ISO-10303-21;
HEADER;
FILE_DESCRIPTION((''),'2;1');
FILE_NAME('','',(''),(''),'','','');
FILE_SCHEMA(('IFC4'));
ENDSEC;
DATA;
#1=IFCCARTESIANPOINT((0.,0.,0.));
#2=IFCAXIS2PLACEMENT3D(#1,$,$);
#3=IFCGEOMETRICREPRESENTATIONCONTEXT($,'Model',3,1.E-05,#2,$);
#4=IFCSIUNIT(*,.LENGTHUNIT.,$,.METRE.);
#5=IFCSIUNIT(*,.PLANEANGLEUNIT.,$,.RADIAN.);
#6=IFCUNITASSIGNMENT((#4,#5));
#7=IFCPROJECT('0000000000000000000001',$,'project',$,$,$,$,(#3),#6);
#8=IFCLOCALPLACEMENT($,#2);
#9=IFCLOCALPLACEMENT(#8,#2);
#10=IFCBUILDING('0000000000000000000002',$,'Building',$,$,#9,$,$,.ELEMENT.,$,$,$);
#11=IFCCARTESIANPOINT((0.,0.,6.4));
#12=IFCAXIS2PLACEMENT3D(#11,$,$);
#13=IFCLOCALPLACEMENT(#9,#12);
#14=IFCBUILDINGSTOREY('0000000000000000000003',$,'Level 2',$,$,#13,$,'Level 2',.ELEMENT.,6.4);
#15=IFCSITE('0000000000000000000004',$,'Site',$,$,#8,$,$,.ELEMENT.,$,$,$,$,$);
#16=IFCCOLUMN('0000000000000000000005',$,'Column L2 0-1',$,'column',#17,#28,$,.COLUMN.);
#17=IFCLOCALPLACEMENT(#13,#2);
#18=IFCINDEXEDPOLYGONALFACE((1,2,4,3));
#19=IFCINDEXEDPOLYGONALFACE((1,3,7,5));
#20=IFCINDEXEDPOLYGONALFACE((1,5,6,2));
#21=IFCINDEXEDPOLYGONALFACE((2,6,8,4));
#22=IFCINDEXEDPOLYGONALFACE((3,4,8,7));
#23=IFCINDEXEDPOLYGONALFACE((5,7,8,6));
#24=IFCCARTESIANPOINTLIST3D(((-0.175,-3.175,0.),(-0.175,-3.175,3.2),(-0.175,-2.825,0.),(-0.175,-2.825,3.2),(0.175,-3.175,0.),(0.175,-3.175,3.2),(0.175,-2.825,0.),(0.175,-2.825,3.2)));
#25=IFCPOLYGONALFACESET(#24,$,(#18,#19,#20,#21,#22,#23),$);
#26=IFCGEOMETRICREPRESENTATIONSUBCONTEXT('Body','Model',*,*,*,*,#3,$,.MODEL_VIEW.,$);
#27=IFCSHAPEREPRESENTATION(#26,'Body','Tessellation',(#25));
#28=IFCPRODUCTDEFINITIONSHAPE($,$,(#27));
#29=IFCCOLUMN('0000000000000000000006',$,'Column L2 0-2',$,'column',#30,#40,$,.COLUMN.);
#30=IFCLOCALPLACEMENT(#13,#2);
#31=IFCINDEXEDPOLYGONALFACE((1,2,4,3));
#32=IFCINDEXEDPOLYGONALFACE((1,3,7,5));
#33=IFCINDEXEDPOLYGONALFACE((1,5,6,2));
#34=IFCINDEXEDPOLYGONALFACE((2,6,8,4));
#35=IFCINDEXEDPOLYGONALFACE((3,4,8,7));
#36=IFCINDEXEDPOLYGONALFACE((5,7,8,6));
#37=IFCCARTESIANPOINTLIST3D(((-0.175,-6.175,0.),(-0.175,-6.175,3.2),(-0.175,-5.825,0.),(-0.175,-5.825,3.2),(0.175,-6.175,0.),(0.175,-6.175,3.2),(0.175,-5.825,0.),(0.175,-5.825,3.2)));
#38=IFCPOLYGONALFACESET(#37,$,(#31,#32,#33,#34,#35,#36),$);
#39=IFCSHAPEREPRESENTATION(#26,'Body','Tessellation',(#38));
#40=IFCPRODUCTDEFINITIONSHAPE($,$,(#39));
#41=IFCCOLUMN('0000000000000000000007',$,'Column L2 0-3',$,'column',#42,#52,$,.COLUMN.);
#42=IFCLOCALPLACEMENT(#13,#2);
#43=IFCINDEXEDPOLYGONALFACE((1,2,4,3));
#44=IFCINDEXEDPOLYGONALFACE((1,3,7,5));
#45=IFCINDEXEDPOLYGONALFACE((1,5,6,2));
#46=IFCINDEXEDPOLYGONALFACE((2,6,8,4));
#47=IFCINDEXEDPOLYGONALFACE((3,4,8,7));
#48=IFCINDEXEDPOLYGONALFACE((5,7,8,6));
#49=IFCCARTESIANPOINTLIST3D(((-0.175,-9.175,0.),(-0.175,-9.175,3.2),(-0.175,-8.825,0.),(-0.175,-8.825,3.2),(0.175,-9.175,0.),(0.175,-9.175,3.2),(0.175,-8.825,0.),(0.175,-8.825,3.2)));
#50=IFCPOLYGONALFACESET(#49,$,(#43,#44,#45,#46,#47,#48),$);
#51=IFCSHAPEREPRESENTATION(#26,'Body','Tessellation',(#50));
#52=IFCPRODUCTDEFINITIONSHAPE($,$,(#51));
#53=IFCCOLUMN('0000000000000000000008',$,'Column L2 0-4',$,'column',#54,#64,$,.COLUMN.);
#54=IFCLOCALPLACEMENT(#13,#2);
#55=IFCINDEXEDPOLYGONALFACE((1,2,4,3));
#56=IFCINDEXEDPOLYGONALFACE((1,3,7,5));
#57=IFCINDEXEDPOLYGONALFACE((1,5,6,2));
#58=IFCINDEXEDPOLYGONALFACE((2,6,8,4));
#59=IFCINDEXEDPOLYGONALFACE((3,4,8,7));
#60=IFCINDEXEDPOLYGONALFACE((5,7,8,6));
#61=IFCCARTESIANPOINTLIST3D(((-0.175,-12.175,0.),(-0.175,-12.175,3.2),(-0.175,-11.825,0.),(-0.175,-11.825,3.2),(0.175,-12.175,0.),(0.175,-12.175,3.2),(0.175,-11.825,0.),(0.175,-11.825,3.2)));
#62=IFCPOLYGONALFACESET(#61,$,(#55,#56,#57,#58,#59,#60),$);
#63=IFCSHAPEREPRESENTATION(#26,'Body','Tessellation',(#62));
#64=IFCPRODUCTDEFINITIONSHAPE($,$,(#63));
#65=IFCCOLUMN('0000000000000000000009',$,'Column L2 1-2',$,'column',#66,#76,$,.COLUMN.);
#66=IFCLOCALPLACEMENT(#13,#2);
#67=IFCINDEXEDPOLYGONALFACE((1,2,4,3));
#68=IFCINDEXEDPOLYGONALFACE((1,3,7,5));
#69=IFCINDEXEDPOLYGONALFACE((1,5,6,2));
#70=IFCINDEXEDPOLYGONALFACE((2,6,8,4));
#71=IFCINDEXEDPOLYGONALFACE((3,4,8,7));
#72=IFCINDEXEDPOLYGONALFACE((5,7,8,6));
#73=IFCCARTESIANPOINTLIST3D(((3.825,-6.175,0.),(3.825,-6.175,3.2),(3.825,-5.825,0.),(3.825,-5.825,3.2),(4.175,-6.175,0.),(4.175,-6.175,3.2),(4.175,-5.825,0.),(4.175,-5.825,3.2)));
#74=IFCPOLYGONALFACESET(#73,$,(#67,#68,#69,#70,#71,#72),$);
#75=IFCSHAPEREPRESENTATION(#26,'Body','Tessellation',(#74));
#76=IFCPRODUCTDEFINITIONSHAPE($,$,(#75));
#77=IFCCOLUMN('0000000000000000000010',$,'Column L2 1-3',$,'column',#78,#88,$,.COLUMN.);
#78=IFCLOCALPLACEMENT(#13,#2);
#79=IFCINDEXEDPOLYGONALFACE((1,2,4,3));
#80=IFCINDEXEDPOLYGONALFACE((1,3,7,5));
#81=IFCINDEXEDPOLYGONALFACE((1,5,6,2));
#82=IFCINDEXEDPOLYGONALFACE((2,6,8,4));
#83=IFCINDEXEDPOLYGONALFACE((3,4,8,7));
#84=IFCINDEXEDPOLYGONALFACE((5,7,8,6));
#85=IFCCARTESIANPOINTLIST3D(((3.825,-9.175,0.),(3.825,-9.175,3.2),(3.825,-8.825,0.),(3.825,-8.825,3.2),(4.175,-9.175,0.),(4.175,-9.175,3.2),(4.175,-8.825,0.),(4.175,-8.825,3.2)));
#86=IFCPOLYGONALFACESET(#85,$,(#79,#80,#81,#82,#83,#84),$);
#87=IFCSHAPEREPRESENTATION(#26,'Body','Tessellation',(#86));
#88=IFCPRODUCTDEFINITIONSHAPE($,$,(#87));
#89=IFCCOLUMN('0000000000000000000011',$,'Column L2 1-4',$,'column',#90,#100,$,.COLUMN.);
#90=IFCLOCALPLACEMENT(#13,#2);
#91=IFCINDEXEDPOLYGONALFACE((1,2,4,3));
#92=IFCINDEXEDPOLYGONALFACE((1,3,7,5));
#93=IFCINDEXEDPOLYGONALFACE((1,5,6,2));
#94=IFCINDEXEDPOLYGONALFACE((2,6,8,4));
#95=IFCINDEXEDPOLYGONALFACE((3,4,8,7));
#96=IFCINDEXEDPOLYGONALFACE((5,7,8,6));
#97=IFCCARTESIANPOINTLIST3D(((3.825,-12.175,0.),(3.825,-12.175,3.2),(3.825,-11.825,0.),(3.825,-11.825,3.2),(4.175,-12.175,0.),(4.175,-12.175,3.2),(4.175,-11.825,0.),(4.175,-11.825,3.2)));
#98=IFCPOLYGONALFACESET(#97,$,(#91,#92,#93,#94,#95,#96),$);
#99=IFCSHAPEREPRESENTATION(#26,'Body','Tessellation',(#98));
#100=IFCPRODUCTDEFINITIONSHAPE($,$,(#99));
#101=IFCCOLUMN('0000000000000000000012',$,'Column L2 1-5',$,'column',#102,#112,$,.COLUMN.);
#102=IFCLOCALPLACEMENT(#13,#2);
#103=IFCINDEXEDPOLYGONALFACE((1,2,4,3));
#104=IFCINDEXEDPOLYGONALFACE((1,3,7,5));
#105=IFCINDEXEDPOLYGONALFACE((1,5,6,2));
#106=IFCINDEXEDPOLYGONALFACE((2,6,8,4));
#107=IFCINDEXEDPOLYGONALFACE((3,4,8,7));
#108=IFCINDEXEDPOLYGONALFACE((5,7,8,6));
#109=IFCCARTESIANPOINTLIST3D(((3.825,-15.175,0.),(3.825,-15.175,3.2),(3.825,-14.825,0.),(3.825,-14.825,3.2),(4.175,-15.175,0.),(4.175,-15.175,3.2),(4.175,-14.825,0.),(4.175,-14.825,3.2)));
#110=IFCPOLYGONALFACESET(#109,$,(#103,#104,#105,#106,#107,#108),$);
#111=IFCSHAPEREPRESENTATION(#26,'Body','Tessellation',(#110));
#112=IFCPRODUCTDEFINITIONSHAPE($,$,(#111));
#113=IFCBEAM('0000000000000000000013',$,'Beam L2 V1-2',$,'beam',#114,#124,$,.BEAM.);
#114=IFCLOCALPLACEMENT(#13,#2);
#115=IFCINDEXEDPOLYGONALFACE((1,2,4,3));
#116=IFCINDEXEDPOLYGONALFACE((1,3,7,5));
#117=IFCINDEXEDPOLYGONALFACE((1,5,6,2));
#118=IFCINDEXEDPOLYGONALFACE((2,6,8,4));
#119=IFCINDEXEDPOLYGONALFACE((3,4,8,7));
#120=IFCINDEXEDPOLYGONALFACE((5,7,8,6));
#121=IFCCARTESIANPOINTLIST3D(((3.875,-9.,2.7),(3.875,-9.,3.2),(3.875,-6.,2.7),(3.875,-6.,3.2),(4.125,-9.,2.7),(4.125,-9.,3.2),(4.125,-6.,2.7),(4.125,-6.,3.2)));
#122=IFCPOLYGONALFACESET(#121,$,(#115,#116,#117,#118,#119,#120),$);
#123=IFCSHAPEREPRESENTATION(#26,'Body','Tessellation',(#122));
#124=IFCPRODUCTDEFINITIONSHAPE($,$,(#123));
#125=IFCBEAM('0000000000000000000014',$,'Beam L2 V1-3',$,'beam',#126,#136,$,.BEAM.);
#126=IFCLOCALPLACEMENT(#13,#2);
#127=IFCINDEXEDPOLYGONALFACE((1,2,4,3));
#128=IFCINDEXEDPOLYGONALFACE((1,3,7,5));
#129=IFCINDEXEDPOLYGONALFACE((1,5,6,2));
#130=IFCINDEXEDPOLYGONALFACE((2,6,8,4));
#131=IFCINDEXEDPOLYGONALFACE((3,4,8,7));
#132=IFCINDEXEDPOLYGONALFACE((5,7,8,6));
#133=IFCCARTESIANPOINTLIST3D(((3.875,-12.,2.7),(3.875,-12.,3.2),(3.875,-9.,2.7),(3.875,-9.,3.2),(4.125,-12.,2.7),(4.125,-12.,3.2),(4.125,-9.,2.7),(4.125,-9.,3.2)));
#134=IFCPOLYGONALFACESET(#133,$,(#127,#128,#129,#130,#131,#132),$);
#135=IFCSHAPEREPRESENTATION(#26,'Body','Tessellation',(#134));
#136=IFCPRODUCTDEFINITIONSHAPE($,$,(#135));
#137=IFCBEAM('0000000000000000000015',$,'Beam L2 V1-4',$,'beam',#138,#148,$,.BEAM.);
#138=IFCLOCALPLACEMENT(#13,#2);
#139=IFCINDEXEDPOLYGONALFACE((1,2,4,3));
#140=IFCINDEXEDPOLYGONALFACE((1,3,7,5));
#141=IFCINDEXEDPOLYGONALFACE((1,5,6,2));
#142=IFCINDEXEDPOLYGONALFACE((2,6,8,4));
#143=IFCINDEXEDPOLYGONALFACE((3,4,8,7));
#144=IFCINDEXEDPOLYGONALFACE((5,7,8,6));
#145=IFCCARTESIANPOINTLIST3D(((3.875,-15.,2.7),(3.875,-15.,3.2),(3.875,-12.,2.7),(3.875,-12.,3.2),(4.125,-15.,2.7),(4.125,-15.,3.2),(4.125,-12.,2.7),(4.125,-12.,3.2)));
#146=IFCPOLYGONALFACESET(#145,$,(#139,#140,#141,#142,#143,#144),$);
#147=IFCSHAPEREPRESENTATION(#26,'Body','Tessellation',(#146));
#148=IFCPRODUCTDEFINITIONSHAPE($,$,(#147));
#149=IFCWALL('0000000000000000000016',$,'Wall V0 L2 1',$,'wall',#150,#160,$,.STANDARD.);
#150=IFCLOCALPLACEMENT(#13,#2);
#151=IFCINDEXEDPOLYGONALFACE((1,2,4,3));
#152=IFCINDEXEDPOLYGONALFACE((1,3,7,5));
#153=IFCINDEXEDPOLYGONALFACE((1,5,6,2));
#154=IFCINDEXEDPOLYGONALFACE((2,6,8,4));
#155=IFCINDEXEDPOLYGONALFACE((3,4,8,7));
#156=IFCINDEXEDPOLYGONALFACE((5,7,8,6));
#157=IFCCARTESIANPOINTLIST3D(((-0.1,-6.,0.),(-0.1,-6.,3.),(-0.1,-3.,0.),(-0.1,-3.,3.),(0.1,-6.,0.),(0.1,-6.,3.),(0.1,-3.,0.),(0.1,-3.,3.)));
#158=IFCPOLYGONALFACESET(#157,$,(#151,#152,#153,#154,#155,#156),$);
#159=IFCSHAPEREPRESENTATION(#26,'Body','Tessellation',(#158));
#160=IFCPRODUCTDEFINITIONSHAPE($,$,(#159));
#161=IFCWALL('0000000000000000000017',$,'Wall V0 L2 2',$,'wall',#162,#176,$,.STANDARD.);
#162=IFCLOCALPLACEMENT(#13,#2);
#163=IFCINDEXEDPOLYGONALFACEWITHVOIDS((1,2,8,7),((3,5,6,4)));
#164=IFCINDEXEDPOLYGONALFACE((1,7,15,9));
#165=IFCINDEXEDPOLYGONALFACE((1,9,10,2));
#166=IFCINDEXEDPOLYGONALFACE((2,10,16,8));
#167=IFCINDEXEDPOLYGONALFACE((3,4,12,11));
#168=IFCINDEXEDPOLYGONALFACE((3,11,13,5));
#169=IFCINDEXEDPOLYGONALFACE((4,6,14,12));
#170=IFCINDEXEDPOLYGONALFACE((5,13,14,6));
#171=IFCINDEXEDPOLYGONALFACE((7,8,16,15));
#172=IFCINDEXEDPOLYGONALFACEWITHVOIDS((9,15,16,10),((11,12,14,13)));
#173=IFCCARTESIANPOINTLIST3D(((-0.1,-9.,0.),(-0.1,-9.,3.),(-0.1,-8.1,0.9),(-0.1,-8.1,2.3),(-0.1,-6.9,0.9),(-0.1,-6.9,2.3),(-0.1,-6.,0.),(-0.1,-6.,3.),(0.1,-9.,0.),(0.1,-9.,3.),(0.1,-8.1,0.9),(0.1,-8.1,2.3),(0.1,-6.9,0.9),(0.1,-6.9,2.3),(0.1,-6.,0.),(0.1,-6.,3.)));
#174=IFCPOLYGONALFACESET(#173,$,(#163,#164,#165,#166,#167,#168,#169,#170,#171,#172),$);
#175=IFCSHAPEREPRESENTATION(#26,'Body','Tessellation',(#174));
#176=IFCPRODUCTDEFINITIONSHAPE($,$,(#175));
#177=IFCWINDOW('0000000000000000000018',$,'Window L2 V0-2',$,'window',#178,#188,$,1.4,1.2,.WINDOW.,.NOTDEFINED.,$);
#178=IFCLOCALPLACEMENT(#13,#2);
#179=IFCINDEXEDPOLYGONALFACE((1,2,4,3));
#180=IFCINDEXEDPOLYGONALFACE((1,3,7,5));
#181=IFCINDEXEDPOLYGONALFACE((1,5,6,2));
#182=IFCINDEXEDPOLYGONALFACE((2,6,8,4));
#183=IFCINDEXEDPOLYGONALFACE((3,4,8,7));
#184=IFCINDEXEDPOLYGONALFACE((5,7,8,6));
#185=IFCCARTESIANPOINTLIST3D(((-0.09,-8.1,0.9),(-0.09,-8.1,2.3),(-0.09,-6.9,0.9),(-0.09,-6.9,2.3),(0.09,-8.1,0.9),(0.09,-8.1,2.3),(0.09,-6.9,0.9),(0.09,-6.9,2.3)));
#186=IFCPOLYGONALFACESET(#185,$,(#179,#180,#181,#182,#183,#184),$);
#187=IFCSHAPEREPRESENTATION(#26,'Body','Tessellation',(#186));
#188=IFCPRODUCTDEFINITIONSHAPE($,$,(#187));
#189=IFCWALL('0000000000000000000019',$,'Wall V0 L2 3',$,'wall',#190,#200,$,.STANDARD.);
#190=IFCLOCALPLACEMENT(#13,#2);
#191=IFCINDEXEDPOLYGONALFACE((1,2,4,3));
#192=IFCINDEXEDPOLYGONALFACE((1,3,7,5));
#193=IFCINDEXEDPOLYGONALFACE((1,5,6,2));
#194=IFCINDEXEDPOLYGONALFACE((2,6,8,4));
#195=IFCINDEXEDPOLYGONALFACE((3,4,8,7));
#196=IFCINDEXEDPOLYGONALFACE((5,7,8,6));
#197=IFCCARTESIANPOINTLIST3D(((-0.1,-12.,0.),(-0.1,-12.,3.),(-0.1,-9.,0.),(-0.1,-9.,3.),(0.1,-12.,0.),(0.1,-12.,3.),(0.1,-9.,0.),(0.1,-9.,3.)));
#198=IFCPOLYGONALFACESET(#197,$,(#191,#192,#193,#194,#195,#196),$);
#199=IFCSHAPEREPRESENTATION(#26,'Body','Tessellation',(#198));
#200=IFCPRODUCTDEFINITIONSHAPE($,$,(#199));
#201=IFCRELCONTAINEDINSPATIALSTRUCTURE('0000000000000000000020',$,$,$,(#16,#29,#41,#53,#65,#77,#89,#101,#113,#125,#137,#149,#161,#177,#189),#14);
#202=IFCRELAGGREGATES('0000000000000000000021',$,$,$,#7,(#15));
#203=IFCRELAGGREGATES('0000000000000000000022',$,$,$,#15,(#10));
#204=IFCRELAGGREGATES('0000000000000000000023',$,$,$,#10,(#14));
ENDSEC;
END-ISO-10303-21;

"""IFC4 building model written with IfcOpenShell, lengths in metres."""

from ifc_helpers import new_model, si_unit, frame, frame_2d, origin, origin_2d, place, context, subcontext, project, spatial, rectangle, extrude, element, fill, save


model = new_model("IFC4")

# Units and contexts
model_context = context("Model", 3, precision=1e-05, world=origin())
body_context = subcontext(model_context, "Body", "Model", "MODEL_VIEW")
ifc_project = project(units=[si_unit("LENGTHUNIT", "METRE"), si_unit("PLANEANGLEUNIT", "RADIAN")], contexts=[model_context])

# Site, building, storey
site_placement = place(None, origin())
site = spatial("IfcSite", under=ifc_project, at=site_placement, Name="Site", CompositionType="ELEMENT")
building_placement = place(site_placement, origin())
building = spatial("IfcBuilding", under=site, at=building_placement, Name="Building", CompositionType="ELEMENT")
storey_placement = place(building_placement, frame((0.0, 0.0, 6.4)))
storey = spatial("IfcBuildingStorey", under=building, at=storey_placement, Name="Level 2", LongName="Level 2", CompositionType="ELEMENT", Elevation=6.4)

# Columns
for number, where, name in (
    (1, (0.0, -3.0, 0.0), "Column L2 0-1"),
    (2, (0.0, -6.0, 0.0), "Column L2 0-2"),
    (3, (0.0, -9.0, 0.0), "Column L2 0-3"),
    (4, (0.0, -12.0, 0.0), "Column L2 0-4"),
    (5, (4.0, -6.0, 0.0), "Column L2 1-2"),
    (6, (4.0, -9.0, 0.0), "Column L2 1-3"),
    (7, (4.0, -12.0, 0.0), "Column L2 1-4"),
    (8, (4.0, -15.0, 0.0), "Column L2 1-5"),
):
    element("IfcColumn", number, at=place(storey_placement, frame(where)), inside=storey, Name=name, ObjectType="column", PredefinedType="COLUMN", context=body_context, shape_type="SweptSolid", body=[
        extrude(rectangle(XDim=0.35, YDim=0.35, at=origin_2d()), origin(), (0.0, 0.0, 1.0), 3.2),
    ])

# Beams
for number, where, z_axis, x_axis, name in (
    (9, (4.0, -6.0, 2.95), (0.0, -1.0, 0.0), (0.0, 0.0, 1.0), "Beam L2 V1-2"),
    (10, (4.0, -9.0, 2.95), (0.0, -1.0, 0.0), (0.0, 0.0, 1.0), "Beam L2 V1-3"),
    (11, (4.0, -12.0, 2.95), (0.0, -1.0, 0.0), (0.0, 0.0, 1.0), "Beam L2 V1-4"),
):
    element("IfcBeam", number, at=place(storey_placement, frame(where, z_axis=z_axis, x_axis=x_axis)), inside=storey, Name=name, ObjectType="beam", PredefinedType="BEAM", context=body_context, shape_type="SweptSolid", body=[
        extrude(rectangle(XDim=0.5, YDim=0.25, at=origin_2d()), origin(), (0.0, 0.0, 1.0), 3.0),
    ])

# Wall
wall_1_placement = place(storey_placement, frame((0.0, -3.0, 0.0), z_axis=(0.0, 0.0, 1.0), x_axis=(0.0, -1.0, 0.0)))
element("IfcWall", 12, at=wall_1_placement, inside=storey, Name="Wall V0 L2 1", ObjectType="wall", PredefinedType="STANDARD", context=body_context, shape_type="SweptSolid", body=[
    extrude(rectangle(XDim=3.0, YDim=0.2, at=frame_2d((1.5, 0.0))), origin(), (0.0, 0.0, 1.0), 3.0),
])

# Wall, opening, window
wall_2_placement = place(storey_placement, frame((0.0, -6.0, 0.0), z_axis=(0.0, 0.0, 1.0), x_axis=(0.0, -1.0, 0.0)))
wall_2 = element("IfcWall", 13, at=wall_2_placement, inside=storey, Name="Wall V0 L2 2", ObjectType="wall", PredefinedType="STANDARD", context=body_context, shape_type="SweptSolid", body=[
    extrude(rectangle(XDim=3.0, YDim=0.2, at=frame_2d((1.5, 0.0))), origin(), (0.0, 0.0, 1.0), 3.0),
])
opening_1_placement = place(storey_placement, frame((0.0, -7.5, 0.9), z_axis=(0.0, 0.0, 1.0), x_axis=(0.0, -1.0, 0.0)))
opening_1 = element("IfcOpeningElement", 14, at=opening_1_placement, cuts=wall_2, ObjectType="Opening", PredefinedType="OPENING", context=body_context, shape_type="SweptSolid", body=[
    extrude(rectangle(XDim=1.2, YDim=0.22, at=origin_2d()), origin(), (0.0, 0.0, 1.0), 1.4),
])
window_1_placement = place(storey_placement, frame((0.0, -7.5, 0.9), z_axis=(0.0, 0.0, 1.0), x_axis=(0.0, -1.0, 0.0)))
window_1 = element("IfcWindow", 15, at=window_1_placement, inside=storey, Name="Window L2 V0-2", ObjectType="window", OverallHeight=1.4, OverallWidth=1.2, PartitioningType="NOTDEFINED", PredefinedType="WINDOW", context=body_context, shape_type="SweptSolid", body=[
    extrude(rectangle(XDim=1.2, YDim=0.18, at=origin_2d()), origin(), (0.0, 0.0, 1.0), 1.4),
])
fill(opening_1, window_1)

# Wall
wall_3_placement = place(storey_placement, frame((0.0, -9.0, 0.0), z_axis=(0.0, 0.0, 1.0), x_axis=(0.0, -1.0, 0.0)))
element("IfcWall", 16, at=wall_3_placement, inside=storey, Name="Wall V0 L2 3", ObjectType="wall", PredefinedType="STANDARD", context=body_context, shape_type="SweptSolid", body=[
    extrude(rectangle(XDim=3.0, YDim=0.2, at=frame_2d((1.5, 0.0))), origin(), (0.0, 0.0, 1.0), 3.0),
])

save(model, "model.ifc")
